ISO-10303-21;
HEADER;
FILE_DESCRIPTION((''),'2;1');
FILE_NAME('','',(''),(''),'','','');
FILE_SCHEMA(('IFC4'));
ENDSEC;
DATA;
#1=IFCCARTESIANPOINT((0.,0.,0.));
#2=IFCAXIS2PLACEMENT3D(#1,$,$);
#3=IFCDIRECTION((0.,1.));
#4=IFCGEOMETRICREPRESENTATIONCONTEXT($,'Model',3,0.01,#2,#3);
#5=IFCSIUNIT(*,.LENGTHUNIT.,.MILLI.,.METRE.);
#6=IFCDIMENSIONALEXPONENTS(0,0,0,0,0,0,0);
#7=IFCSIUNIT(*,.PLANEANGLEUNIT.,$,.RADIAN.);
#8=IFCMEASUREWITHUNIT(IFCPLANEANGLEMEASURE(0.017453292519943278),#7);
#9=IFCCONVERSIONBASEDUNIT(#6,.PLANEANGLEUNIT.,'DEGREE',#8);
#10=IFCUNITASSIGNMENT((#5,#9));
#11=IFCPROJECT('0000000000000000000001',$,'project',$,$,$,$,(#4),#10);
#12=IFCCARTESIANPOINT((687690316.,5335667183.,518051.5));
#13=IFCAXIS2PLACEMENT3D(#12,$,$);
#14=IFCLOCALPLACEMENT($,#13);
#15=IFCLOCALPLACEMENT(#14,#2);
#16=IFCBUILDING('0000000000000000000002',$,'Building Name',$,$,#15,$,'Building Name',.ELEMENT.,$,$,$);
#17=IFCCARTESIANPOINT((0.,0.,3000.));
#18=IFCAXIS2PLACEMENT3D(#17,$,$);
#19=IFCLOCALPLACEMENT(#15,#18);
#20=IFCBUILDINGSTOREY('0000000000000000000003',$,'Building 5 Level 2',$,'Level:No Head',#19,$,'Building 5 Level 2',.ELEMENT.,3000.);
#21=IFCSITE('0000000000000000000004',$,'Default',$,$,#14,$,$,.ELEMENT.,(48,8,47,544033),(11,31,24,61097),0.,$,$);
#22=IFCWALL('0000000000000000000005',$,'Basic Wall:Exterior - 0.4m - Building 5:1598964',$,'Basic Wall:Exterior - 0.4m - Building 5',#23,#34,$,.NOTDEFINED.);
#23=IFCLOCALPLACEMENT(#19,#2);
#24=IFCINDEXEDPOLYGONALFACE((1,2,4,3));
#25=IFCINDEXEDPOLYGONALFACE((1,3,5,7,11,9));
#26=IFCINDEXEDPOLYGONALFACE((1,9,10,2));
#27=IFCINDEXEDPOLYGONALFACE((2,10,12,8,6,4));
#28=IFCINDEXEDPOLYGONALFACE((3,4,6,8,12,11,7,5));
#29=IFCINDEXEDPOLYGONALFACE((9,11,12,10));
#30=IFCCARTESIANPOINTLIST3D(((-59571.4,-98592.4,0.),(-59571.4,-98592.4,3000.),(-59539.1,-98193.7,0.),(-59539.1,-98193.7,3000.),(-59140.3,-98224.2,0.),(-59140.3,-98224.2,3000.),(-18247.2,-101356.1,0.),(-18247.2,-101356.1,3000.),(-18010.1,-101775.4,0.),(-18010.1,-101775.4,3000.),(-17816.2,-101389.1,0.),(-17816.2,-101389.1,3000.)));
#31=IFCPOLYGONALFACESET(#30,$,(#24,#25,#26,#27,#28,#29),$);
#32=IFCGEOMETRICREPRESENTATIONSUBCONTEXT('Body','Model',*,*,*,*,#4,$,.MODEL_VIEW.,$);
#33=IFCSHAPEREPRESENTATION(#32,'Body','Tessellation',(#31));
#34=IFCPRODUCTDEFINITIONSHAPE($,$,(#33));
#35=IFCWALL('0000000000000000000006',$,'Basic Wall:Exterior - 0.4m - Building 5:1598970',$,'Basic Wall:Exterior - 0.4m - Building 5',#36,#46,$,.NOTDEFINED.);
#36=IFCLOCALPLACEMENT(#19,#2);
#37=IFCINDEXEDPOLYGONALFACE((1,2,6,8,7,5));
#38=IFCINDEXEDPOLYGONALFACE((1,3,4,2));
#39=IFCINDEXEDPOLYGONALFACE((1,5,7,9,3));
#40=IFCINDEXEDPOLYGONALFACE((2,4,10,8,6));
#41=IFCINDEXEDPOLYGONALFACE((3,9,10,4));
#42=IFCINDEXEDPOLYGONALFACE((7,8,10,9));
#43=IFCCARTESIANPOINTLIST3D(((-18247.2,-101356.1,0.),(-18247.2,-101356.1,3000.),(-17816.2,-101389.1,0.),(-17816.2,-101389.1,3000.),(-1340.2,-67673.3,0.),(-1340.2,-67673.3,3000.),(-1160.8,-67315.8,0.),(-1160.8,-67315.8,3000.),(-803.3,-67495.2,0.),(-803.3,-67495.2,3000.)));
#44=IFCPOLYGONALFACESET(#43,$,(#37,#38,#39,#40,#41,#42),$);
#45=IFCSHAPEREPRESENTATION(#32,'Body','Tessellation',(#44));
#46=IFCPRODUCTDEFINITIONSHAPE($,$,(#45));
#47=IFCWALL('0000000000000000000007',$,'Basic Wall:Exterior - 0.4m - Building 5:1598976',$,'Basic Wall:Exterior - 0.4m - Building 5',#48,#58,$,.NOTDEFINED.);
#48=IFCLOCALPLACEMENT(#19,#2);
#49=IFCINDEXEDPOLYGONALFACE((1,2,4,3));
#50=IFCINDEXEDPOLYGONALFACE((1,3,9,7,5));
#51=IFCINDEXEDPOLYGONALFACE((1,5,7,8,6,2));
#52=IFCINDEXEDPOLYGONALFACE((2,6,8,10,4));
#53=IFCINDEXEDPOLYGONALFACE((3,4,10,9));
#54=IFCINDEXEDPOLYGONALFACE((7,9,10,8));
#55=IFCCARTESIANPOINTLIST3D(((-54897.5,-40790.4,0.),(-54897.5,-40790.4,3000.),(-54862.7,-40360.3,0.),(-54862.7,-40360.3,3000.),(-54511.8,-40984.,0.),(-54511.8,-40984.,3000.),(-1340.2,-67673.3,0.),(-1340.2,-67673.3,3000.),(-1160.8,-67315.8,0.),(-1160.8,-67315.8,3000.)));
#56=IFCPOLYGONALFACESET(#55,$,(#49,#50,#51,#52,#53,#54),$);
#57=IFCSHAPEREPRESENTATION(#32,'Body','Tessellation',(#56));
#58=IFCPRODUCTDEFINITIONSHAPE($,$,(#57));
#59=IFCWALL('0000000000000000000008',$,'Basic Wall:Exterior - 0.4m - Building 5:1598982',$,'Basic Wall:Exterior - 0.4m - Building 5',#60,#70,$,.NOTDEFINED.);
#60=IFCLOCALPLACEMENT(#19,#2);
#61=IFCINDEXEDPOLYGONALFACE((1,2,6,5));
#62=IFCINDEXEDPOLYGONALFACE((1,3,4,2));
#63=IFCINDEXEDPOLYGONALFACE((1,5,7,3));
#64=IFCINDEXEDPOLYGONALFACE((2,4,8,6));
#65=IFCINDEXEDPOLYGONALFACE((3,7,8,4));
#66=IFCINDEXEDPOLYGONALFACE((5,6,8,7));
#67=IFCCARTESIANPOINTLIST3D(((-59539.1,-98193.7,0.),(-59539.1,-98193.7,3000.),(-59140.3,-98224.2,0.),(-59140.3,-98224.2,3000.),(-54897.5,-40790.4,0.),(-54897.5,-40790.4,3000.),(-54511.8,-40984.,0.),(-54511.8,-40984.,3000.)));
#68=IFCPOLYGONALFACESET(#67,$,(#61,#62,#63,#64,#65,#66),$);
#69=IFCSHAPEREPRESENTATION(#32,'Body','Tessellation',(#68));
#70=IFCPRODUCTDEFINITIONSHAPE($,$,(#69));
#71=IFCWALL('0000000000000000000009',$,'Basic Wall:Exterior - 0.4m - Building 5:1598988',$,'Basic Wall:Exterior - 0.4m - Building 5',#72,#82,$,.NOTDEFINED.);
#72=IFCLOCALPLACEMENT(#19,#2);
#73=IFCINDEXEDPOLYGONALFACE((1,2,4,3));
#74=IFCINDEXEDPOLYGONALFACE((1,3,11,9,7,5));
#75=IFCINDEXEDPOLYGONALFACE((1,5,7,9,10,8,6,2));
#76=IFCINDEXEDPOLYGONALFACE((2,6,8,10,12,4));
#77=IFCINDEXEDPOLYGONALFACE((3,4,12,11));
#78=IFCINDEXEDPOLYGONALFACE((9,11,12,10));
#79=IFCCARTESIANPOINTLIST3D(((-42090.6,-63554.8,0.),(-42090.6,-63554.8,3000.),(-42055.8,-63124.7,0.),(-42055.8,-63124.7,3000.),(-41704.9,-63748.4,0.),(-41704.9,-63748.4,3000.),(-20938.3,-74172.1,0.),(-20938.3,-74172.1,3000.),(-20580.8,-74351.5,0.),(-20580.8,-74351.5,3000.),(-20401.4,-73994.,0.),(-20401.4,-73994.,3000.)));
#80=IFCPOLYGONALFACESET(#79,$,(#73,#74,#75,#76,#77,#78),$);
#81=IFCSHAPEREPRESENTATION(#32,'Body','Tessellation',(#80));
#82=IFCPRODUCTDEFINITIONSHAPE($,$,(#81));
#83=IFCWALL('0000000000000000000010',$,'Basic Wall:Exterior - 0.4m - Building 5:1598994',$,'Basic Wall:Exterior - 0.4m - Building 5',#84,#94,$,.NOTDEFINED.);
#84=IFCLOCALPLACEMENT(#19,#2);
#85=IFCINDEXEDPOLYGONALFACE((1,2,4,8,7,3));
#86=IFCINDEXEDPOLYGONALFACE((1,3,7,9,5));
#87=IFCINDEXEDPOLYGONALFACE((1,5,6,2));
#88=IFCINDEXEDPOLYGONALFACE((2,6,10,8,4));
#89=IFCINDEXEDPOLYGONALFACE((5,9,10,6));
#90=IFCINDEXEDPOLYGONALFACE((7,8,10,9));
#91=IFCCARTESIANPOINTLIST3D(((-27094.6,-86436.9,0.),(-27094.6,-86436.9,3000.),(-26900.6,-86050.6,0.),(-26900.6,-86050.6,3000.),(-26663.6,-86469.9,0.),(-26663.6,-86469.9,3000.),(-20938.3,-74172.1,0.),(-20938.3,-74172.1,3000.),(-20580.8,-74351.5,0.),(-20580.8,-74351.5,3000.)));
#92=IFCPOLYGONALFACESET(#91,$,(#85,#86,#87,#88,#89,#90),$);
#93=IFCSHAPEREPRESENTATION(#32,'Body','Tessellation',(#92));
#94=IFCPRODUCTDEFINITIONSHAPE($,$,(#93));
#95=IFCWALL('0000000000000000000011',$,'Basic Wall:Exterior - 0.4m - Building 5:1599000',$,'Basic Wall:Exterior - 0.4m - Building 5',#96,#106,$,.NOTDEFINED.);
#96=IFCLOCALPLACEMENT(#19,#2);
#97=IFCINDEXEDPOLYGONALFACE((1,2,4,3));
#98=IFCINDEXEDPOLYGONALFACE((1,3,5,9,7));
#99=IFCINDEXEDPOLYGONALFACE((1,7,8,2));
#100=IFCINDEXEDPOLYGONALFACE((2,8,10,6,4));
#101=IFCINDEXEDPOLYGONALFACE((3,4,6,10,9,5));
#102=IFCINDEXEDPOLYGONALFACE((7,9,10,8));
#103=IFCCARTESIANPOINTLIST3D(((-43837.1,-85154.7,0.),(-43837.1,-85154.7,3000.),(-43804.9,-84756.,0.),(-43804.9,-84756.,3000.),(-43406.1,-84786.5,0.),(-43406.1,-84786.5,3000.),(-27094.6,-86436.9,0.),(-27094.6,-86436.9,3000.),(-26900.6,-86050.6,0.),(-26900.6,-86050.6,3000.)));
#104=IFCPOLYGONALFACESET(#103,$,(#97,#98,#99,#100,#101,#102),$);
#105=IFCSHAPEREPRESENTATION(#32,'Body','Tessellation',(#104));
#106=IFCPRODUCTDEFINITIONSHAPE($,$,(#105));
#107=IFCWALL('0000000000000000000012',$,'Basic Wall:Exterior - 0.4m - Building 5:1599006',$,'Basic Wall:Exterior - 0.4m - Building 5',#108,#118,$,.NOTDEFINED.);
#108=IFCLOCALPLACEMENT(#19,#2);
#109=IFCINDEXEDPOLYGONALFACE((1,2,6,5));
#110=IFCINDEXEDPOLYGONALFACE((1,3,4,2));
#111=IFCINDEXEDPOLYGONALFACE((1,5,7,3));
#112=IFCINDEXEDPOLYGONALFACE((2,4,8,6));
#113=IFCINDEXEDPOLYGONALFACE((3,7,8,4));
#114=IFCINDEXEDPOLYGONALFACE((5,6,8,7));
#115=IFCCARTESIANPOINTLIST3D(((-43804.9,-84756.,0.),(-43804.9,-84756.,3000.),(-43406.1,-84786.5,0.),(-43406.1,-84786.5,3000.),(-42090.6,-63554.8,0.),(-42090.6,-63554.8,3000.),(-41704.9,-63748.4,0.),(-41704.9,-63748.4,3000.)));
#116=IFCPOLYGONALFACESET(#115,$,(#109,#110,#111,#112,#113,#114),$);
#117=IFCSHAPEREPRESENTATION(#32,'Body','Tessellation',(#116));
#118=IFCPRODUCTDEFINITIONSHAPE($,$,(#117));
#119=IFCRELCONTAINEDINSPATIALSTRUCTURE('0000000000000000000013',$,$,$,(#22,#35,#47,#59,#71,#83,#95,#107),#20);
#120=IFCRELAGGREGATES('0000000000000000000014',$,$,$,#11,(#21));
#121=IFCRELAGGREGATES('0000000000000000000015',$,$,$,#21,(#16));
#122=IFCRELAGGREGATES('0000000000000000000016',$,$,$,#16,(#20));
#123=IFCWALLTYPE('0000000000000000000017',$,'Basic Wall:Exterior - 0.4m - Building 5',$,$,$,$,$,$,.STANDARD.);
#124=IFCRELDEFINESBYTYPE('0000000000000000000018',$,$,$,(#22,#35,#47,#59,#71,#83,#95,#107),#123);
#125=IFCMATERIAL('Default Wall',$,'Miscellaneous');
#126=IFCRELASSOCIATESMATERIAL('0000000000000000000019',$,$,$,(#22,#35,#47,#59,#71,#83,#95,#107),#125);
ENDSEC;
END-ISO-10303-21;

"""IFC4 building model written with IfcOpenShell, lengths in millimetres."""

from ifc_helpers import new_model, entity, si_unit, converted_unit, direction, frame, origin, place, context, subcontext, project, spatial, indexed_curve, outline, extrude, material, type_object, element, save


model = new_model("IFC4")

# Units and contexts
model_context = context("Model", 3, precision=0.01, world=origin(), true_north=direction((0.0, 1.0)))
body_context = subcontext(model_context, "Body", "Model", "MODEL_VIEW")
ifc_project = project(units=[si_unit("LENGTHUNIT", "METRE", prefix="MILLI"), converted_unit("PLANEANGLEUNIT", "DEGREE", entity("IfcPlaneAngleMeasure", 0.017453292519943278), si_unit("PLANEANGLEUNIT", "RADIAN"), dimensions=[0, 0, 0, 0, 0, 0, 0])], contexts=[model_context])

# Site, building, storey
site_placement = place(None, frame((687690316.0, 5335667183.0, 518051.5)))
site = spatial("IfcSite", under=ifc_project, at=site_placement, Name="Default", CompositionType="ELEMENT", RefLatitude=(48, 8, 47, 544033), RefLongitude=(11, 31, 24, 61097), RefElevation=0.0)
building_placement = place(site_placement, origin())
building = spatial("IfcBuilding", under=site, at=building_placement, Name="Building Name", LongName="Building Name", CompositionType="ELEMENT")
storey_placement = place(building_placement, frame((0.0, 0.0, 3000.0)))
storey = spatial("IfcBuildingStorey", under=building, at=storey_placement, Name="Building 5 Level 2", ObjectType="Level:No Head", LongName="Building 5 Level 2", CompositionType="ELEMENT", Elevation=3000.0)

# Walls
ifc_material_1 = material(Name="Default Wall", Category="Miscellaneous")
wall_type = type_object("IfcWallType", Name="Basic Wall:Exterior - 0.4m - Building 5", PredefinedType="STANDARD")
wall_1_placement = place(storey_placement, frame((-59556.1, -98393.0, 0.0), z_axis=(0.0, 0.0, 1.0), x_axis=(0.99708, -0.076363, 0.0)))
element("IfcWall", 1, at=wall_1_placement, inside=storey, type_object=wall_type, material=ifc_material_1, Name="Basic Wall:Exterior - 0.4m - Building 5:1598964", ObjectType="Basic Wall:Exterior - 0.4m - Building 5", PredefinedType="NOTDEFINED", context=body_context, shape_type="SweptSolid", body=[
    extrude(outline(indexed_curve([(41683.0, -200.0), (41846.9, 200.0), (41414.6, 200.0), (401.7, 200.0), (1.7, 200.0), (0.0, -200.0), (41683.0, -200.0)], self_intersect=False)), origin(), (0.0, 0.0, 1.0), 3000.0),
])
wall_2_placement = place(storey_placement, frame((-18068.4, -101445.8, 0.0), z_axis=(0.0, 0.0, 1.0), x_axis=(0.448604, 0.893731, 0.0)))
element("IfcWall", 2, at=wall_2_placement, inside=storey, type_object=wall_type, material=ifc_material_1, Name="Basic Wall:Exterior - 0.4m - Building 5:1598970", ObjectType="Basic Wall:Exterior - 0.4m - Building 5", PredefinedType="NOTDEFINED", context=body_context, shape_type="SweptSolid", body=[
    extrude(outline(indexed_curve([(38087.9, -200.0), (38087.9, 200.0), (37687.9, 200.0), (0.0, 200.0), (163.8, -200.0), (38087.9, -200.0)], self_intersect=False)), origin(), (0.0, 0.0, 1.0), 3000.0),
])
wall_3_placement = place(storey_placement, frame((-1250.5, -67494.5, 0.0), z_axis=(0.0, 0.0, 1.0), x_axis=(-0.893731, 0.448604, 0.0)))
element("IfcWall", 3, at=wall_3_placement, inside=storey, type_object=wall_type, material=ifc_material_1, Name="Basic Wall:Exterior - 0.4m - Building 5:1598976", ObjectType="Basic Wall:Exterior - 0.4m - Building 5", PredefinedType="NOTDEFINED", context=body_context, shape_type="SweptSolid", body=[
    extrude(outline(indexed_curve([(60087.4, -200.0), (59925.5, 200.0), (59494.0, 200.0), (0.0, 200.0), (0.0, -200.0), (60087.4, -200.0)], self_intersect=False)), origin(), (0.0, 0.0, 1.0), 3000.0),
])
wall_4_placement = place(storey_placement, frame((-54698.1, -40806.5, 0.0), z_axis=(0.0, 0.0, 1.0), x_axis=(-0.080597, -0.996747, 0.0)))
element("IfcWall", 4, at=wall_4_placement, inside=storey, type_object=wall_type, material=ifc_material_1, Name="Basic Wall:Exterior - 0.4m - Building 5:1598982", ObjectType="Basic Wall:Exterior - 0.4m - Building 5", PredefinedType="NOTDEFINED", context=body_context, shape_type="SweptSolid", body=[
    extrude(outline(indexed_curve([(57590.6, -200.0), (57588.9, 200.0), (161.9, 200.0), (0.0, -200.0), (57590.6, -200.0)], self_intersect=False)), origin(), (0.0, 0.0, 1.0), 3000.0),
])
wall_5_placement = place(storey_placement, frame((-42145.5, -63303.4, 0.0), z_axis=(0.0, 0.0, 1.0), x_axis=(0.893731, -0.448604, 0.0)))
element("IfcWall", 5, at=wall_5_placement, inside=storey, type_object=wall_type, material=ifc_material_1, Name="Basic Wall:Exterior - 0.4m - Building 5:1598988", ObjectType="Basic Wall:Exterior - 0.4m - Building 5", PredefinedType="NOTDEFINED", context=body_context, shape_type="SweptSolid", body=[
    extrude(outline(indexed_curve([(24229.3, -200.0), (24229.3, 200.0), (0.0, 200.0), (161.9, -200.0), (593.4, -200.0), (23829.3, -200.0), (24229.3, -200.0)], self_intersect=False)), origin(), (0.0, 0.0, 1.0), 3000.0),
])
wall_6_placement = place(storey_placement, frame((-20759.5, -74261.8, 0.0), z_axis=(0.0, 0.0, 1.0), x_axis=(-0.448604, -0.893731, 0.0)))
element("IfcWall", 6, at=wall_6_placement, inside=storey, type_object=wall_type, material=ifc_material_1, Name="Basic Wall:Exterior - 0.4m - Building 5:1598994", ObjectType="Basic Wall:Exterior - 0.4m - Building 5", PredefinedType="NOTDEFINED", context=body_context, shape_type="SweptSolid", body=[
    extrude(outline(indexed_curve([(13723.2, -200.0), (13559.3, 200.0), (0.0, 200.0), (0.0, -200.0), (13290.9, -200.0), (13723.2, -200.0)], self_intersect=False)), origin(), (0.0, 0.0, 1.0), 3000.0),
])
wall_7_placement = place(storey_placement, frame((-26915.9, -86250.0, 0.0), z_axis=(0.0, 0.0, 1.0), x_axis=(-0.99708, 0.076363, 0.0)))
element("IfcWall", 7, at=wall_7_placement, inside=storey, type_object=wall_type, material=ifc_material_1, Name="Basic Wall:Exterior - 0.4m - Building 5:1599000", ObjectType="Basic Wall:Exterior - 0.4m - Building 5", PredefinedType="NOTDEFINED", context=body_context, shape_type="SweptSolid", body=[
    extrude(outline(indexed_curve([(16953.8, -200.0), (16955.5, 200.0), (163.8, 200.0), (0.0, -200.0), (16553.8, -200.0), (16953.8, -200.0)], self_intersect=False)), origin(), (0.0, 0.0, 1.0), 3000.0),
])
wall_8_placement = place(storey_placement, frame((-43605.6, -84772.1, 0.0), z_axis=(0.0, 0.0, 1.0), x_axis=(0.080597, 0.996747, 0.0)))
element("IfcWall", 8, at=wall_8_placement, inside=storey, type_object=wall_type, material=ifc_material_1, Name="Basic Wall:Exterior - 0.4m - Building 5:1599006", ObjectType="Basic Wall:Exterior - 0.4m - Building 5", PredefinedType="NOTDEFINED", context=body_context, shape_type="SweptSolid", body=[
    extrude(outline(indexed_curve([(21108.5, -200.0), (21270.4, 200.0), (0.0, 200.0), (1.7, -200.0), (21108.5, -200.0)], self_intersect=False)), origin(), (0.0, 0.0, 1.0), 3000.0),
])

save(model, "model.ifc")
